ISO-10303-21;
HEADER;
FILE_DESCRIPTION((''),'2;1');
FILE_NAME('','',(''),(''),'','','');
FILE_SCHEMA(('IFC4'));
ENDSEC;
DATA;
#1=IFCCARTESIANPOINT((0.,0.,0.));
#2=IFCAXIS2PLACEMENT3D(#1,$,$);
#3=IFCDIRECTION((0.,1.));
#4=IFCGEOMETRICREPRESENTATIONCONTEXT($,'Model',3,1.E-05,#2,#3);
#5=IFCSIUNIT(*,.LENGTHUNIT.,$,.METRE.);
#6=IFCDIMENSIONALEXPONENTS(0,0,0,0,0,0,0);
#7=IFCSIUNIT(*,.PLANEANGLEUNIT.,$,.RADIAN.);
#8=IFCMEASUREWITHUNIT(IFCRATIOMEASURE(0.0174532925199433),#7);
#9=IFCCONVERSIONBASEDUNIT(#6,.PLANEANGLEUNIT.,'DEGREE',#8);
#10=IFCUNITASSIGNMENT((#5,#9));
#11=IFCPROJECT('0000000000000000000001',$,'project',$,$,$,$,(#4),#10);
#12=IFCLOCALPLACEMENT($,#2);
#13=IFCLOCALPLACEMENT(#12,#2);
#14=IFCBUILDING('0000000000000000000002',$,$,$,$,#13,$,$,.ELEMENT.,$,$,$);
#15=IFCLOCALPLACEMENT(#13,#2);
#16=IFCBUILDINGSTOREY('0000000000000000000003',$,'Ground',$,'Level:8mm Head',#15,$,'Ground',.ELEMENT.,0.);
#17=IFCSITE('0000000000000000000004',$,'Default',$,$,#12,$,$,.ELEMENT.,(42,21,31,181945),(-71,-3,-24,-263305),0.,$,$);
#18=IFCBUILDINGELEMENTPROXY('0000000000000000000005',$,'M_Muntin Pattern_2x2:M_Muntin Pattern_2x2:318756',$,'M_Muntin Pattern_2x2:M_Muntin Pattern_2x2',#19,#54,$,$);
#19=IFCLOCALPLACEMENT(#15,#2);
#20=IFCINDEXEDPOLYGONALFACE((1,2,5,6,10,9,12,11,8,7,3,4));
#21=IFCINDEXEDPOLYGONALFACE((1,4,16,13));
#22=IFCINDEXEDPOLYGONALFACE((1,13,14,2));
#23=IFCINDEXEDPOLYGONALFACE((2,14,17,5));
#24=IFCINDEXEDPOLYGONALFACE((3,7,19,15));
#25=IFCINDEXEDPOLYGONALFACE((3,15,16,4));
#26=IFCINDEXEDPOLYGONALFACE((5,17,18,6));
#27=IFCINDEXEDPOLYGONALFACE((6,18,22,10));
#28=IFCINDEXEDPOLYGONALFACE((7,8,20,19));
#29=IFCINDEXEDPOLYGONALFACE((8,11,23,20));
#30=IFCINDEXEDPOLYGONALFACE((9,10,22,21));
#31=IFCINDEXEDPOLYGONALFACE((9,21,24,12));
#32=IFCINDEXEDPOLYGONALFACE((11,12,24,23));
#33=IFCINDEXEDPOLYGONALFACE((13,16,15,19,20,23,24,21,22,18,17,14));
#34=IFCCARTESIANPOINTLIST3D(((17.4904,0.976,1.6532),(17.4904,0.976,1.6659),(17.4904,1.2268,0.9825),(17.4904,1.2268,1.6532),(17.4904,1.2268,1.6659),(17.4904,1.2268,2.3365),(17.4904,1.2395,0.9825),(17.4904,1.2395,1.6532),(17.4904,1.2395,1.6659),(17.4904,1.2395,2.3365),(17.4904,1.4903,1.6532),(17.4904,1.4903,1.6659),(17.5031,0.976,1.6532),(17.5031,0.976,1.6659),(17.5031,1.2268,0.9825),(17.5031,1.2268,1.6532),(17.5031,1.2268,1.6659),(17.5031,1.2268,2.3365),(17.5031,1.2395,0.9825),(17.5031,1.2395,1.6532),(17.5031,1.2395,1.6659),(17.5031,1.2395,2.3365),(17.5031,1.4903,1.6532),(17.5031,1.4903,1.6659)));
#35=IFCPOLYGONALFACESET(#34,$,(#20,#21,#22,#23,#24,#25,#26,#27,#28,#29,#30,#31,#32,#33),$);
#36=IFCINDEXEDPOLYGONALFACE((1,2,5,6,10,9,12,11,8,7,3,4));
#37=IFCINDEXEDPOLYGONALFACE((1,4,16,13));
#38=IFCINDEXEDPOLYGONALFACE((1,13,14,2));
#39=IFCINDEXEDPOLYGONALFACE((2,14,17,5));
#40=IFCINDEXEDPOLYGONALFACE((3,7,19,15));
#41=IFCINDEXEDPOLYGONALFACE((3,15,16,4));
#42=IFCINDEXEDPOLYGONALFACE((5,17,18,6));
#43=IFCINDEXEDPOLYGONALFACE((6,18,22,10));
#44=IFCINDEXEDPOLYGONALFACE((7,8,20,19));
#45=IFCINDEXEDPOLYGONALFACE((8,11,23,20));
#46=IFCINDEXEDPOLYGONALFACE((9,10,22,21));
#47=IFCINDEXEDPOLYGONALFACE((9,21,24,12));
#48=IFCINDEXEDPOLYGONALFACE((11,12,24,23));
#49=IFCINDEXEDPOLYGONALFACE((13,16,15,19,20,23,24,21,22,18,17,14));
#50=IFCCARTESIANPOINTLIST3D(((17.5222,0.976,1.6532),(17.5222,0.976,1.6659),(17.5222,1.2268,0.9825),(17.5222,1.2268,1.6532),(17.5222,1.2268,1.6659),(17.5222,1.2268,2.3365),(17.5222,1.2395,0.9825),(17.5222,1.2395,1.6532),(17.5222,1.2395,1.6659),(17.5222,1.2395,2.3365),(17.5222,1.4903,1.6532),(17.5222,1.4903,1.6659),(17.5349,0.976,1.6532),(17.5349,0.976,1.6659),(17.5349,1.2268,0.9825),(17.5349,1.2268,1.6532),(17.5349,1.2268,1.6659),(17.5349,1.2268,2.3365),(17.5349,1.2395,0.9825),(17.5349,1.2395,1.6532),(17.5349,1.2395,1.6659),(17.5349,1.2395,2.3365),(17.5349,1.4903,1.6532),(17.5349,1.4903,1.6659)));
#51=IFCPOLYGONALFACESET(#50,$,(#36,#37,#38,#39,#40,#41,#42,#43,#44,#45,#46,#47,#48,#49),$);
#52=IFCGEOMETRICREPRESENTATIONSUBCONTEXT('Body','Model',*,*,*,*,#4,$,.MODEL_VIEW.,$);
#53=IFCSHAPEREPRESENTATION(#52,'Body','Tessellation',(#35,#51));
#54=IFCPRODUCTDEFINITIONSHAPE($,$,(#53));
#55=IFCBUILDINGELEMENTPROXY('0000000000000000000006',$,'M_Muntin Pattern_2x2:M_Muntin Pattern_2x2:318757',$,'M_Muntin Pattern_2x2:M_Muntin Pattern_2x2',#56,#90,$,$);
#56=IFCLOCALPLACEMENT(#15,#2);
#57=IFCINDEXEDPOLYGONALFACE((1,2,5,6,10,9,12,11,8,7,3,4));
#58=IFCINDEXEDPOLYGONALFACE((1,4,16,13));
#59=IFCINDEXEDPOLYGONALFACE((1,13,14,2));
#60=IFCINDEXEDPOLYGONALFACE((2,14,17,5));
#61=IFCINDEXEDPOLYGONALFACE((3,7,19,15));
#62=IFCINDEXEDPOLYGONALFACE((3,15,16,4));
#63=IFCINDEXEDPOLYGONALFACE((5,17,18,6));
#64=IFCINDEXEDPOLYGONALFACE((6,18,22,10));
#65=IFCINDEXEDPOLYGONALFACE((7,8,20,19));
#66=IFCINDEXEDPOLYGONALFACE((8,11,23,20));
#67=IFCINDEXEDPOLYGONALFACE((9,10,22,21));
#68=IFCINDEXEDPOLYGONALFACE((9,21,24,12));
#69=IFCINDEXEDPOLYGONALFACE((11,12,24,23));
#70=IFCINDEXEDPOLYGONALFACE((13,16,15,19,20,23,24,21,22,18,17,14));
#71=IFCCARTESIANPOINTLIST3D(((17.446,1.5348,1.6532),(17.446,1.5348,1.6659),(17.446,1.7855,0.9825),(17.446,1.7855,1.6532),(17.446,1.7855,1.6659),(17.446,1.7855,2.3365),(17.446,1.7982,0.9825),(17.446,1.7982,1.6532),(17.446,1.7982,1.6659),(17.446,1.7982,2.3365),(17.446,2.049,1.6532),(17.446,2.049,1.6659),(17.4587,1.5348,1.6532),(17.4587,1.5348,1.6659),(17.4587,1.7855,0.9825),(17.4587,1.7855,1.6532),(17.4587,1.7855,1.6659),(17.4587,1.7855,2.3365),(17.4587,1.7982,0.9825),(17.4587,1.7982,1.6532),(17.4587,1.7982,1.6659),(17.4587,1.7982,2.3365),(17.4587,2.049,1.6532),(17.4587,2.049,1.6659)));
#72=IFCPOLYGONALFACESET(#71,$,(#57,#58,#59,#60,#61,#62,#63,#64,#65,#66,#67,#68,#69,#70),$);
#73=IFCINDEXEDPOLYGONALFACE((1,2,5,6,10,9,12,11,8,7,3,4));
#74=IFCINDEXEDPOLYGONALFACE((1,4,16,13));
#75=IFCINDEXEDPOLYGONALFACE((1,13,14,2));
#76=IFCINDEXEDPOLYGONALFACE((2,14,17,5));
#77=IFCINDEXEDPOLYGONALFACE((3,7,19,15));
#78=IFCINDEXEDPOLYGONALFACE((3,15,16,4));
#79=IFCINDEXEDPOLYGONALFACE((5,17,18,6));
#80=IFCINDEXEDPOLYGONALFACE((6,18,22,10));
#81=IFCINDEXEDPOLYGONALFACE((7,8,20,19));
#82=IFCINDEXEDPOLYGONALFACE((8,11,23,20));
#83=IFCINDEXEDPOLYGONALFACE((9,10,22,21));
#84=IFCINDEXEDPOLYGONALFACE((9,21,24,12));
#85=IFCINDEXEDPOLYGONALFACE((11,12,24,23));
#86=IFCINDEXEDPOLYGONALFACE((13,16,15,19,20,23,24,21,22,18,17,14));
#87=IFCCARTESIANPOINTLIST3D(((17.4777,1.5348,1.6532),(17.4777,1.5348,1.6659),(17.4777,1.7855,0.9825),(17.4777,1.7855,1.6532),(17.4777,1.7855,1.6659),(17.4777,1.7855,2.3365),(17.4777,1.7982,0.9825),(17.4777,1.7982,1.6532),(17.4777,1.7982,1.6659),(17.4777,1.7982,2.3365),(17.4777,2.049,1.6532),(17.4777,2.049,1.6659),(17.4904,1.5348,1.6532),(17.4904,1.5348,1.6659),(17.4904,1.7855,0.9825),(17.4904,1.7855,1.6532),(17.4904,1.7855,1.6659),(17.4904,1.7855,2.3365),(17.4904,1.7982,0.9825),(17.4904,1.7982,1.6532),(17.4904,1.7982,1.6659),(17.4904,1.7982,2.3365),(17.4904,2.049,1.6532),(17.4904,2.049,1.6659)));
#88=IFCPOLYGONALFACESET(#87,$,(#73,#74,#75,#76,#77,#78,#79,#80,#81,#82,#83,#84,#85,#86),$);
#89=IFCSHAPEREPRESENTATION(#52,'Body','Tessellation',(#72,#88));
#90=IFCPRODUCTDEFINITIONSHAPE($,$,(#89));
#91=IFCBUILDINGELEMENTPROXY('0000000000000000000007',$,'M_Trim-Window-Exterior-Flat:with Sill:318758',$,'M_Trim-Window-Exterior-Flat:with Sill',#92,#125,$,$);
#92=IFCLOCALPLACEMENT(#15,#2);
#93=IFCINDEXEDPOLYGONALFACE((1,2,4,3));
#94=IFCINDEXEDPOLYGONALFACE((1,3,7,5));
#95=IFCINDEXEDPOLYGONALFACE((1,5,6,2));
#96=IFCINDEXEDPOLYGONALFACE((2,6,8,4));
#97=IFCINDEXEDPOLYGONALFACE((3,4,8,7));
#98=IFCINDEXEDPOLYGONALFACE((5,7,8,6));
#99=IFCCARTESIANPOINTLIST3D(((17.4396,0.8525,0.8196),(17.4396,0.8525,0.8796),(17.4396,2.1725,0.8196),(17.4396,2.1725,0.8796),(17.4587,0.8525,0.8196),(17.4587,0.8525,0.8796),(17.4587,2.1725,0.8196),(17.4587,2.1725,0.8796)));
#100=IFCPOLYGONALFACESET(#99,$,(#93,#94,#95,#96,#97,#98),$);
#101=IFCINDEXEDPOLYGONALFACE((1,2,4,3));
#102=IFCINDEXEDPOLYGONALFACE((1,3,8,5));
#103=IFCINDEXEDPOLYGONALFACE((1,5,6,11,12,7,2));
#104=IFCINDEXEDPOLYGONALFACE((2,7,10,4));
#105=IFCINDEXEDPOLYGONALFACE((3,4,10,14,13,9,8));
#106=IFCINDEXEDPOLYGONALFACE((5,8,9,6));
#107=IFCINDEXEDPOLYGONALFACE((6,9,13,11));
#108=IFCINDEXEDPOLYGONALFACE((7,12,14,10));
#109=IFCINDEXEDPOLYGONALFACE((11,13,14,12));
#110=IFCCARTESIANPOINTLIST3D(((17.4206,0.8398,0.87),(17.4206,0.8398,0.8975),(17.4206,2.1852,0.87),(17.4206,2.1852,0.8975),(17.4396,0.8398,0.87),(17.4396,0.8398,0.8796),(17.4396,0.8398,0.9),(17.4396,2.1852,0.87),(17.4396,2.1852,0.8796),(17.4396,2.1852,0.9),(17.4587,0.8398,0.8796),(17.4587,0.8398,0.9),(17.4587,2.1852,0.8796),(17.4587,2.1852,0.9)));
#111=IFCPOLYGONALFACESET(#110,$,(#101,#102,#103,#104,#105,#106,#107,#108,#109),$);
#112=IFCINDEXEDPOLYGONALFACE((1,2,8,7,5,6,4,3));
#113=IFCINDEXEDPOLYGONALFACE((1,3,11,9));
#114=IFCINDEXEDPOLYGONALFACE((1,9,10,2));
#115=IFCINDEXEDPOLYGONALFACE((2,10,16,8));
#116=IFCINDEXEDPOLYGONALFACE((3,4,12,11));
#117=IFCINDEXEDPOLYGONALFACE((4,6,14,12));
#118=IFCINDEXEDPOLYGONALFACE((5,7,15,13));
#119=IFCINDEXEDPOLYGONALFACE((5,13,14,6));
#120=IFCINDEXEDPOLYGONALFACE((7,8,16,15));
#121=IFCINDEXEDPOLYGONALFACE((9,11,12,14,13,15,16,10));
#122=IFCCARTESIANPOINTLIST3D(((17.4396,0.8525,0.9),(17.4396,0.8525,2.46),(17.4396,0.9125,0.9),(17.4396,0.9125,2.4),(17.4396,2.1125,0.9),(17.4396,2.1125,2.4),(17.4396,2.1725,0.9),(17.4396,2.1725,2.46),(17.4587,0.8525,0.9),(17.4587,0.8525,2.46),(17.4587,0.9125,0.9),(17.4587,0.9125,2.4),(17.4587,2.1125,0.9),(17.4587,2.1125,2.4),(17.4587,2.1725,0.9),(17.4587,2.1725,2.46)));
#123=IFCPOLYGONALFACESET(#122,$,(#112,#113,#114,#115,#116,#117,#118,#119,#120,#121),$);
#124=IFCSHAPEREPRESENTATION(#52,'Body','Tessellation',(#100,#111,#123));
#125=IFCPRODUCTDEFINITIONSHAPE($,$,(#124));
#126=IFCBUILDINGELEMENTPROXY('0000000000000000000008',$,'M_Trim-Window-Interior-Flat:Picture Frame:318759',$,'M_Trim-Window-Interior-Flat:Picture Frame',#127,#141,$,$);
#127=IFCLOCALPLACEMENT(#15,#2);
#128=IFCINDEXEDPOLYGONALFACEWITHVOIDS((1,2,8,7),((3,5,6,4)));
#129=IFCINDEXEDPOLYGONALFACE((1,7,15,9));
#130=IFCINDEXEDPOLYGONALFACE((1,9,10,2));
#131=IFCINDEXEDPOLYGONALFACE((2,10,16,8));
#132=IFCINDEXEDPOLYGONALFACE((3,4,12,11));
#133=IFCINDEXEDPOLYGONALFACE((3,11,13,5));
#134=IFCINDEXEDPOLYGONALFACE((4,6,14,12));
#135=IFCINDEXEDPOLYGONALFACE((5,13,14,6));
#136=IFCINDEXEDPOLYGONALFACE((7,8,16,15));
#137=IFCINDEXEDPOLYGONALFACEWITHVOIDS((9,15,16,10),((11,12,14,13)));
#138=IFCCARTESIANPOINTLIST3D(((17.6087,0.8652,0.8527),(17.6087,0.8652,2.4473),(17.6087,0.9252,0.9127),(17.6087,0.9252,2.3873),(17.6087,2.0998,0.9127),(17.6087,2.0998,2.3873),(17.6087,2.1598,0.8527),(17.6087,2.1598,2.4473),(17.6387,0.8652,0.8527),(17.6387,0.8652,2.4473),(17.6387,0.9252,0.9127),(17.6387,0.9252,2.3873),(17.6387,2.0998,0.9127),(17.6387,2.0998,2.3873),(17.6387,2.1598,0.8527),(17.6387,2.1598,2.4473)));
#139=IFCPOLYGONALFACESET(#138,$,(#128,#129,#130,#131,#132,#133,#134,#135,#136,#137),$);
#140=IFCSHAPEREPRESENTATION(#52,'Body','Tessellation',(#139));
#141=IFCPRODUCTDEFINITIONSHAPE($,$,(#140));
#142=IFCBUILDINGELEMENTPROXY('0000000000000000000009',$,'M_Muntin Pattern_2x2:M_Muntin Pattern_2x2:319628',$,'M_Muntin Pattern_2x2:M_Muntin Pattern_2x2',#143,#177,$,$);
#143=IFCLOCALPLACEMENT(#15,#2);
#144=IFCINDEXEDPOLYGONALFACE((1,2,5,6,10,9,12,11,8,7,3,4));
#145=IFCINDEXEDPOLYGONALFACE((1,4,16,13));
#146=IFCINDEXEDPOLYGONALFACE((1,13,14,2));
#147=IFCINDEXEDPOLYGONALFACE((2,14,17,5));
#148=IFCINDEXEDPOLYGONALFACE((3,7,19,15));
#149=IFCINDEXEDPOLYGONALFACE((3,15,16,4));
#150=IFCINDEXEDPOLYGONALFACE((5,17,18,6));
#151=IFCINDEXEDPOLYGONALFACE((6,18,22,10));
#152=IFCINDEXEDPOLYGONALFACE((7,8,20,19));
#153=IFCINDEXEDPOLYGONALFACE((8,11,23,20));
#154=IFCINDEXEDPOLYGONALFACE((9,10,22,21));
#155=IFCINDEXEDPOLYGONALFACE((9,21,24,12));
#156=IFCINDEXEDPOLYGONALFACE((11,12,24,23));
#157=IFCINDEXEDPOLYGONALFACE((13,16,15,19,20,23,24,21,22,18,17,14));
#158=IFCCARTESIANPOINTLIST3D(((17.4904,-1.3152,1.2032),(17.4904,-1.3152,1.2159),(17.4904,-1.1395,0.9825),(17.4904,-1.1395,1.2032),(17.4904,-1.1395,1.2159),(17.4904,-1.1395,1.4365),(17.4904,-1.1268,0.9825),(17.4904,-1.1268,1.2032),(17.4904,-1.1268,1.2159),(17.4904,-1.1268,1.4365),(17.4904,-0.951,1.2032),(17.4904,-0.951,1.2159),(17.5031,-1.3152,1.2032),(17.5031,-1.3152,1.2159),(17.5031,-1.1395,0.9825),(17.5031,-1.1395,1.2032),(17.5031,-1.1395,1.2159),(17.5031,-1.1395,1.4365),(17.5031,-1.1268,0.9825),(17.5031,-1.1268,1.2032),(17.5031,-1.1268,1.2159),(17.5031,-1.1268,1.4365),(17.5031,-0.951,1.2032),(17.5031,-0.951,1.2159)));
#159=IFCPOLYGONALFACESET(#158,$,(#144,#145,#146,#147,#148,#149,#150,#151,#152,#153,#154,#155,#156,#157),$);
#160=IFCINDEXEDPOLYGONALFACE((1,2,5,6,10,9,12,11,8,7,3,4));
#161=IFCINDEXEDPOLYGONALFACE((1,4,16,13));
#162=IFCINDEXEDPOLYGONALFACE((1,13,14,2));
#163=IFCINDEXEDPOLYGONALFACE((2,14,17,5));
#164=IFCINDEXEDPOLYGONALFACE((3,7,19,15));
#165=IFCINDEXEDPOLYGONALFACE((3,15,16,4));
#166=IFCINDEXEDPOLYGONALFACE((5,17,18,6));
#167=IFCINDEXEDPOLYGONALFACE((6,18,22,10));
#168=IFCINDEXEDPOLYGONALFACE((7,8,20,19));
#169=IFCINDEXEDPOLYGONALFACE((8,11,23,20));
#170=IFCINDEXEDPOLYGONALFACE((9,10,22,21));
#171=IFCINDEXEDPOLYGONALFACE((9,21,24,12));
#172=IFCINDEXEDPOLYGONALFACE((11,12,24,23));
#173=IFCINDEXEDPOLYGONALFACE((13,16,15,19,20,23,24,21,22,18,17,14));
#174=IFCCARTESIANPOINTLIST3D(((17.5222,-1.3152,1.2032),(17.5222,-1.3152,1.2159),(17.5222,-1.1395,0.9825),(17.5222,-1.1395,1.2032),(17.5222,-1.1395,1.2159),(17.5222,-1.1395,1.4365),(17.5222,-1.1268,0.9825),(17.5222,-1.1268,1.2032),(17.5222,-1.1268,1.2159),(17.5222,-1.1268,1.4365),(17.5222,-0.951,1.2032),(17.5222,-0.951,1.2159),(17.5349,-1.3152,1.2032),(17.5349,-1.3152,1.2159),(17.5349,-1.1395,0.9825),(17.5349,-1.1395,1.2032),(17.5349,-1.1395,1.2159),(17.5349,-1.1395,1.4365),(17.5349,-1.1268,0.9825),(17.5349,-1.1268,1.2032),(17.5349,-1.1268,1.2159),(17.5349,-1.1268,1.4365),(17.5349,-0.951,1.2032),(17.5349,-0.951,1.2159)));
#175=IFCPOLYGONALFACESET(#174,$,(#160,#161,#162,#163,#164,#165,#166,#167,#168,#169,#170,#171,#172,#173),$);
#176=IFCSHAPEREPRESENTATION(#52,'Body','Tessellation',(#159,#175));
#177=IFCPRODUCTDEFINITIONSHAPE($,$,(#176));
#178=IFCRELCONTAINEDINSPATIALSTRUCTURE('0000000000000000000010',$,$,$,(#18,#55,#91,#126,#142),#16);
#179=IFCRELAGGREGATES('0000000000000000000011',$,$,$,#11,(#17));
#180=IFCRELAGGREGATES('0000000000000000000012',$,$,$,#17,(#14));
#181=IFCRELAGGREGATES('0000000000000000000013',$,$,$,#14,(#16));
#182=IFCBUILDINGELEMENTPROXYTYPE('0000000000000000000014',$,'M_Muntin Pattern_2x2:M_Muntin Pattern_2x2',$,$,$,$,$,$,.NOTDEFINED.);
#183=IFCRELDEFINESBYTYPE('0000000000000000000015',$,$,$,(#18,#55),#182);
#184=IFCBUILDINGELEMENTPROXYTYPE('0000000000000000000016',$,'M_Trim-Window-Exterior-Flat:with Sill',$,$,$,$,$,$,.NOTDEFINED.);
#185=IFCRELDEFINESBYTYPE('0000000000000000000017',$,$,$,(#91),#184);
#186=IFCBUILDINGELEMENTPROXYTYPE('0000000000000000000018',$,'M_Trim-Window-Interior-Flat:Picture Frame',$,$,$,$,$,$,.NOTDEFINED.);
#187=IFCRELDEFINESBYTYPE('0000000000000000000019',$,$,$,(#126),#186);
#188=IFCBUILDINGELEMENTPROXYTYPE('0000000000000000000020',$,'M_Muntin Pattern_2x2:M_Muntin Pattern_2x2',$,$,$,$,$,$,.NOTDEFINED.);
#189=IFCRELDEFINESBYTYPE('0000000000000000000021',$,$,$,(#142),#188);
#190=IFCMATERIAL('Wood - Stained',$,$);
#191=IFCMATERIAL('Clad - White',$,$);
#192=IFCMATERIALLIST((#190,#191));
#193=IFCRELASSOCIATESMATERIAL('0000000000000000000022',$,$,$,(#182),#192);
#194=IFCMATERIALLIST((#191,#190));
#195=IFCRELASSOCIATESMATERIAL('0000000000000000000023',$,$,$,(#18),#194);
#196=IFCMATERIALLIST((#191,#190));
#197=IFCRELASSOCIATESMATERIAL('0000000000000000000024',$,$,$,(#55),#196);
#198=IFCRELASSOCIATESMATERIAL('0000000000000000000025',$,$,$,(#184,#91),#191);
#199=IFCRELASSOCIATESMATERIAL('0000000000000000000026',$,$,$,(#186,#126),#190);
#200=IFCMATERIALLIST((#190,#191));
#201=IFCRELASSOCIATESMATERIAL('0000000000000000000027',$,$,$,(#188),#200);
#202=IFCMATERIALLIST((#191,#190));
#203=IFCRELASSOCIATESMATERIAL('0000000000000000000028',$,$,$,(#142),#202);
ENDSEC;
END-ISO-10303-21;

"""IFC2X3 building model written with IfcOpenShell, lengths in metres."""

from ifc_helpers import new_model, entity, si_unit, converted_unit, direction, frame, frame_2d, origin, place, context, subcontext, project, spatial, polyline, rectangle, outline, extrude, source, transform, mapped, material, material_list, type_object, type_shapes, element, save


model = new_model("IFC2X3")

# Units and contexts
model_context = context("Model", 3, precision=1e-05, world=origin(), true_north=direction((0.0, 1.0)))
body_context = subcontext(model_context, "Body", "Model", "MODEL_VIEW")
ifc_project = project(units=[si_unit("LENGTHUNIT", "METRE"), converted_unit("PLANEANGLEUNIT", "DEGREE", entity("IfcRatioMeasure", 0.0174532925199433), si_unit("PLANEANGLEUNIT", "RADIAN"), dimensions=[0, 0, 0, 0, 0, 0, 0])], contexts=[model_context])

# Site, building, storey
site_placement = place(None, origin())
site = spatial("IfcSite", under=ifc_project, at=site_placement, Name="Default", CompositionType="ELEMENT", RefLatitude=(42, 21, 31, 181945), RefLongitude=(-71, -3, -24, -263305), RefElevation=0.0)
building_placement = place(site_placement, origin())
building = spatial("IfcBuilding", under=site, at=building_placement, CompositionType="ELEMENT")
storey_placement = place(building_placement, origin())
storey = spatial("IfcBuildingStorey", under=building, at=storey_placement, Name="Ground", ObjectType="Level:8mm Head", LongName="Ground", CompositionType="ELEMENT", Elevation=0.0)

# Building element proxies
ifc_material_1 = material(Name="Clad - White")
ifc_material_2 = material(Name="Wood - Stained")
ifc_material_list_1 = material_list([ifc_material_1, ifc_material_2])
ifc_material_list_2 = material_list([ifc_material_2, ifc_material_1])
building_element_proxy_type_1 = type_object("IfcBuildingElementProxyType", Name="M_Muntin Pattern_2x2:M_Muntin Pattern_2x2", PredefinedType="NOTDEFINED", material=ifc_material_list_2)
shared_shape_1 = source(origin(), body_context, "Body", "SweptSolid", [
    extrude(outline(polyline([(0.0064, -0.0064), (0.677, -0.0064), (0.677, 0.0063), (0.0064, 0.0063), (0.0064, 0.2571), (-0.0063, 0.2571), (-0.0063, 0.0063), (-0.677, 0.0063), (-0.677, -0.0064), (-0.0063, -0.0064), (-0.0063, -0.2571), (0.0064, -0.2571), (0.0064, -0.0064)])), frame((0.0, -0.0222, 0.677), z_axis=(0.0, 1.0, 0.0), x_axis=(0.0, 0.0, 1.0)), (0.0, 0.0, 1.0), 0.0127),
    extrude(outline(polyline([(0.0064, -0.0064), (0.677, -0.0064), (0.677, 0.0063), (0.0064, 0.0063), (0.0064, 0.2571), (-0.0063, 0.2571), (-0.0063, 0.0063), (-0.677, 0.0063), (-0.677, -0.0064), (-0.0063, -0.0064), (-0.0063, -0.2571), (0.0064, -0.2571), (0.0064, -0.0064)])), frame((0.0, 0.0095, 0.677), z_axis=(0.0, 1.0, 0.0), x_axis=(0.0, 0.0, 1.0)), (0.0, 0.0, 1.0), 0.0127),
])
type_shapes(building_element_proxy_type_1, [shared_shape_1])
proxy_1_placement = place(storey_placement, frame((17.5126, 1.2332, 0.9825), z_axis=(0.0, 0.0, 1.0), x_axis=(0.0, -1.0, 0.0)))
element("IfcBuildingElementProxy", 1, at=proxy_1_placement, inside=storey, type_object=building_element_proxy_type_1, material=ifc_material_list_1, Name="M_Muntin Pattern_2x2:M_Muntin Pattern_2x2:318756", ObjectType="M_Muntin Pattern_2x2:M_Muntin Pattern_2x2", context=body_context, shape_type="MappedRepresentation", body=[
    mapped(shared_shape_1, transform((0.0, 0.0, 0.0), scale=1.0)),
])
ifc_material_list_3 = material_list([ifc_material_1, ifc_material_2])
proxy_2_placement = place(storey_placement, frame((17.4682, 1.7919, 0.9825), z_axis=(0.0, 0.0, 1.0), x_axis=(0.0, -1.0, 0.0)))
element("IfcBuildingElementProxy", 2, at=proxy_2_placement, inside=storey, type_object=building_element_proxy_type_1, material=ifc_material_list_3, Name="M_Muntin Pattern_2x2:M_Muntin Pattern_2x2:318757", ObjectType="M_Muntin Pattern_2x2:M_Muntin Pattern_2x2", context=body_context, shape_type="MappedRepresentation", body=[
    mapped(shared_shape_1, transform((0.0, 0.0, 0.0), scale=1.0)),
])
building_element_proxy_type_2 = type_object("IfcBuildingElementProxyType", Name="M_Trim-Window-Exterior-Flat:with Sill", PredefinedType="NOTDEFINED", material=ifc_material_1)
shared_shape_2 = source(origin(), body_context, "Body", "SweptSolid", [
    extrude(rectangle(XDim=0.06, YDim=1.32, at=frame_2d((0.0, 0.0), x_axis=(1.0, 0.0))), frame((0.0, 1.5504, 0.0), z_axis=(0.0, 0.0, 1.0), x_axis=(0.0, 1.0, 0.0)), (0.0, 0.0, 1.0), 0.0191),
    extrude(outline(polyline([(-0.0152, -0.019), (0.0123, -0.019), (0.0148, 0.0), (0.0148, 0.019), (-0.0057, 0.019), (-0.0057, 0.0), (-0.0152, 0.0), (-0.0152, -0.019)])), frame((-0.6727, 1.5148, 0.019), z_axis=(1.0, 0.0, 0.0), x_axis=(0.0, -1.0, 0.0)), (0.0, 0.0, 1.0), 1.3454),
    extrude(outline(polyline([(-0.66, -0.795), (0.66, -0.795), (0.66, 0.765), (0.6, 0.765), (0.6, -0.735), (-0.6, -0.735), (-0.6, 0.765), (-0.66, 0.765), (-0.66, -0.795)])), frame((0.0, 0.735, 0.0)), (0.0, 0.0, 1.0), 0.0191),
])
type_shapes(building_element_proxy_type_2, [shared_shape_2])
proxy_3_placement = place(storey_placement, frame((17.4587, 1.5125, 2.4), z_axis=(-1.0, 0.0, 0.0), x_axis=(0.0, 1.0, 0.0)))
element("IfcBuildingElementProxy", 3, at=proxy_3_placement, inside=storey, type_object=building_element_proxy_type_2, material=ifc_material_1, Name="M_Trim-Window-Exterior-Flat:with Sill:318758", ObjectType="M_Trim-Window-Exterior-Flat:with Sill", context=body_context, shape_type="MappedRepresentation", body=[
    mapped(shared_shape_2, transform((0.0, 0.0, 0.0), scale=1.0)),
])
building_element_proxy_type_3 = type_object("IfcBuildingElementProxyType", Name="M_Trim-Window-Interior-Flat:Picture Frame", PredefinedType="NOTDEFINED", material=ifc_material_2)
shared_shape_3 = source(origin(), body_context, "Body", "SweptSolid", [
    extrude(outline(polyline([(-0.7973, -0.6473), (0.7973, -0.6473), (0.7973, 0.6473), (-0.7973, 0.6473), (-0.7973, -0.6473)]), holes=[polyline([(-0.7373, -0.5873), (-0.7373, 0.5873), (0.7373, 0.5873), (0.7373, -0.5873), (-0.7373, -0.5873)])]), frame((0.0, 0.75, 0.0), z_axis=(0.0, 0.0, 1.0), x_axis=(0.0, 1.0, 0.0)), (0.0, 0.0, 1.0), 0.03),
])
type_shapes(building_element_proxy_type_3, [shared_shape_3])
proxy_4_placement = place(storey_placement, frame((17.6087, 1.5125, 2.4), z_axis=(1.0, 0.0, 0.0), x_axis=(0.0, -1.0, 0.0)))
element("IfcBuildingElementProxy", 4, at=proxy_4_placement, inside=storey, type_object=building_element_proxy_type_3, material=ifc_material_2, Name="M_Trim-Window-Interior-Flat:Picture Frame:318759", ObjectType="M_Trim-Window-Interior-Flat:Picture Frame", context=body_context, shape_type="MappedRepresentation", body=[
    mapped(shared_shape_3, transform((0.0, 0.0, 0.0), scale=1.0)),
])
ifc_material_list_4 = material_list([ifc_material_1, ifc_material_2])
ifc_material_list_5 = material_list([ifc_material_2, ifc_material_1])
building_element_proxy_type_4 = type_object("IfcBuildingElementProxyType", Name="M_Muntin Pattern_2x2:M_Muntin Pattern_2x2", PredefinedType="NOTDEFINED", material=ifc_material_list_5)
shared_shape_4 = source(origin(), body_context, "Body", "SweptSolid", [
    extrude(outline(polyline([(0.0064, -0.0064), (0.227, -0.0064), (0.227, 0.0063), (0.0064, 0.0063), (0.0064, 0.1821), (-0.0063, 0.1821), (-0.0063, 0.0063), (-0.227, 0.0063), (-0.227, -0.0064), (-0.0063, -0.0064), (-0.0063, -0.1821), (0.0064, -0.1821), (0.0064, -0.0064)])), frame((0.0, 0.0095, 0.227), z_axis=(0.0, 1.0, 0.0), x_axis=(0.0, 0.0, 1.0)), (0.0, 0.0, 1.0), 0.0127),
    extrude(outline(polyline([(0.0064, -0.0064), (0.227, -0.0064), (0.227, 0.0063), (0.0064, 0.0063), (0.0064, 0.1821), (-0.0063, 0.1821), (-0.0063, 0.0063), (-0.227, 0.0063), (-0.227, -0.0064), (-0.0063, -0.0064), (-0.0063, -0.1821), (0.0064, -0.1821), (0.0064, -0.0064)])), frame((0.0, -0.0222, 0.227), z_axis=(0.0, 1.0, 0.0), x_axis=(0.0, 0.0, 1.0)), (0.0, 0.0, 1.0), 0.0127),
])
type_shapes(building_element_proxy_type_4, [shared_shape_4])
proxy_5_placement = place(storey_placement, frame((17.5126, -1.1331, 0.9825), z_axis=(0.0, 0.0, 1.0), x_axis=(0.0, 1.0, 0.0)))
element("IfcBuildingElementProxy", 5, at=proxy_5_placement, inside=storey, type_object=building_element_proxy_type_4, material=ifc_material_list_4, Name="M_Muntin Pattern_2x2:M_Muntin Pattern_2x2:319628", ObjectType="M_Muntin Pattern_2x2:M_Muntin Pattern_2x2", context=body_context, shape_type="MappedRepresentation", body=[
    mapped(shared_shape_4, transform((0.0, 0.0, 0.0), scale=1.0)),
])

save(model, "model.ifc")
